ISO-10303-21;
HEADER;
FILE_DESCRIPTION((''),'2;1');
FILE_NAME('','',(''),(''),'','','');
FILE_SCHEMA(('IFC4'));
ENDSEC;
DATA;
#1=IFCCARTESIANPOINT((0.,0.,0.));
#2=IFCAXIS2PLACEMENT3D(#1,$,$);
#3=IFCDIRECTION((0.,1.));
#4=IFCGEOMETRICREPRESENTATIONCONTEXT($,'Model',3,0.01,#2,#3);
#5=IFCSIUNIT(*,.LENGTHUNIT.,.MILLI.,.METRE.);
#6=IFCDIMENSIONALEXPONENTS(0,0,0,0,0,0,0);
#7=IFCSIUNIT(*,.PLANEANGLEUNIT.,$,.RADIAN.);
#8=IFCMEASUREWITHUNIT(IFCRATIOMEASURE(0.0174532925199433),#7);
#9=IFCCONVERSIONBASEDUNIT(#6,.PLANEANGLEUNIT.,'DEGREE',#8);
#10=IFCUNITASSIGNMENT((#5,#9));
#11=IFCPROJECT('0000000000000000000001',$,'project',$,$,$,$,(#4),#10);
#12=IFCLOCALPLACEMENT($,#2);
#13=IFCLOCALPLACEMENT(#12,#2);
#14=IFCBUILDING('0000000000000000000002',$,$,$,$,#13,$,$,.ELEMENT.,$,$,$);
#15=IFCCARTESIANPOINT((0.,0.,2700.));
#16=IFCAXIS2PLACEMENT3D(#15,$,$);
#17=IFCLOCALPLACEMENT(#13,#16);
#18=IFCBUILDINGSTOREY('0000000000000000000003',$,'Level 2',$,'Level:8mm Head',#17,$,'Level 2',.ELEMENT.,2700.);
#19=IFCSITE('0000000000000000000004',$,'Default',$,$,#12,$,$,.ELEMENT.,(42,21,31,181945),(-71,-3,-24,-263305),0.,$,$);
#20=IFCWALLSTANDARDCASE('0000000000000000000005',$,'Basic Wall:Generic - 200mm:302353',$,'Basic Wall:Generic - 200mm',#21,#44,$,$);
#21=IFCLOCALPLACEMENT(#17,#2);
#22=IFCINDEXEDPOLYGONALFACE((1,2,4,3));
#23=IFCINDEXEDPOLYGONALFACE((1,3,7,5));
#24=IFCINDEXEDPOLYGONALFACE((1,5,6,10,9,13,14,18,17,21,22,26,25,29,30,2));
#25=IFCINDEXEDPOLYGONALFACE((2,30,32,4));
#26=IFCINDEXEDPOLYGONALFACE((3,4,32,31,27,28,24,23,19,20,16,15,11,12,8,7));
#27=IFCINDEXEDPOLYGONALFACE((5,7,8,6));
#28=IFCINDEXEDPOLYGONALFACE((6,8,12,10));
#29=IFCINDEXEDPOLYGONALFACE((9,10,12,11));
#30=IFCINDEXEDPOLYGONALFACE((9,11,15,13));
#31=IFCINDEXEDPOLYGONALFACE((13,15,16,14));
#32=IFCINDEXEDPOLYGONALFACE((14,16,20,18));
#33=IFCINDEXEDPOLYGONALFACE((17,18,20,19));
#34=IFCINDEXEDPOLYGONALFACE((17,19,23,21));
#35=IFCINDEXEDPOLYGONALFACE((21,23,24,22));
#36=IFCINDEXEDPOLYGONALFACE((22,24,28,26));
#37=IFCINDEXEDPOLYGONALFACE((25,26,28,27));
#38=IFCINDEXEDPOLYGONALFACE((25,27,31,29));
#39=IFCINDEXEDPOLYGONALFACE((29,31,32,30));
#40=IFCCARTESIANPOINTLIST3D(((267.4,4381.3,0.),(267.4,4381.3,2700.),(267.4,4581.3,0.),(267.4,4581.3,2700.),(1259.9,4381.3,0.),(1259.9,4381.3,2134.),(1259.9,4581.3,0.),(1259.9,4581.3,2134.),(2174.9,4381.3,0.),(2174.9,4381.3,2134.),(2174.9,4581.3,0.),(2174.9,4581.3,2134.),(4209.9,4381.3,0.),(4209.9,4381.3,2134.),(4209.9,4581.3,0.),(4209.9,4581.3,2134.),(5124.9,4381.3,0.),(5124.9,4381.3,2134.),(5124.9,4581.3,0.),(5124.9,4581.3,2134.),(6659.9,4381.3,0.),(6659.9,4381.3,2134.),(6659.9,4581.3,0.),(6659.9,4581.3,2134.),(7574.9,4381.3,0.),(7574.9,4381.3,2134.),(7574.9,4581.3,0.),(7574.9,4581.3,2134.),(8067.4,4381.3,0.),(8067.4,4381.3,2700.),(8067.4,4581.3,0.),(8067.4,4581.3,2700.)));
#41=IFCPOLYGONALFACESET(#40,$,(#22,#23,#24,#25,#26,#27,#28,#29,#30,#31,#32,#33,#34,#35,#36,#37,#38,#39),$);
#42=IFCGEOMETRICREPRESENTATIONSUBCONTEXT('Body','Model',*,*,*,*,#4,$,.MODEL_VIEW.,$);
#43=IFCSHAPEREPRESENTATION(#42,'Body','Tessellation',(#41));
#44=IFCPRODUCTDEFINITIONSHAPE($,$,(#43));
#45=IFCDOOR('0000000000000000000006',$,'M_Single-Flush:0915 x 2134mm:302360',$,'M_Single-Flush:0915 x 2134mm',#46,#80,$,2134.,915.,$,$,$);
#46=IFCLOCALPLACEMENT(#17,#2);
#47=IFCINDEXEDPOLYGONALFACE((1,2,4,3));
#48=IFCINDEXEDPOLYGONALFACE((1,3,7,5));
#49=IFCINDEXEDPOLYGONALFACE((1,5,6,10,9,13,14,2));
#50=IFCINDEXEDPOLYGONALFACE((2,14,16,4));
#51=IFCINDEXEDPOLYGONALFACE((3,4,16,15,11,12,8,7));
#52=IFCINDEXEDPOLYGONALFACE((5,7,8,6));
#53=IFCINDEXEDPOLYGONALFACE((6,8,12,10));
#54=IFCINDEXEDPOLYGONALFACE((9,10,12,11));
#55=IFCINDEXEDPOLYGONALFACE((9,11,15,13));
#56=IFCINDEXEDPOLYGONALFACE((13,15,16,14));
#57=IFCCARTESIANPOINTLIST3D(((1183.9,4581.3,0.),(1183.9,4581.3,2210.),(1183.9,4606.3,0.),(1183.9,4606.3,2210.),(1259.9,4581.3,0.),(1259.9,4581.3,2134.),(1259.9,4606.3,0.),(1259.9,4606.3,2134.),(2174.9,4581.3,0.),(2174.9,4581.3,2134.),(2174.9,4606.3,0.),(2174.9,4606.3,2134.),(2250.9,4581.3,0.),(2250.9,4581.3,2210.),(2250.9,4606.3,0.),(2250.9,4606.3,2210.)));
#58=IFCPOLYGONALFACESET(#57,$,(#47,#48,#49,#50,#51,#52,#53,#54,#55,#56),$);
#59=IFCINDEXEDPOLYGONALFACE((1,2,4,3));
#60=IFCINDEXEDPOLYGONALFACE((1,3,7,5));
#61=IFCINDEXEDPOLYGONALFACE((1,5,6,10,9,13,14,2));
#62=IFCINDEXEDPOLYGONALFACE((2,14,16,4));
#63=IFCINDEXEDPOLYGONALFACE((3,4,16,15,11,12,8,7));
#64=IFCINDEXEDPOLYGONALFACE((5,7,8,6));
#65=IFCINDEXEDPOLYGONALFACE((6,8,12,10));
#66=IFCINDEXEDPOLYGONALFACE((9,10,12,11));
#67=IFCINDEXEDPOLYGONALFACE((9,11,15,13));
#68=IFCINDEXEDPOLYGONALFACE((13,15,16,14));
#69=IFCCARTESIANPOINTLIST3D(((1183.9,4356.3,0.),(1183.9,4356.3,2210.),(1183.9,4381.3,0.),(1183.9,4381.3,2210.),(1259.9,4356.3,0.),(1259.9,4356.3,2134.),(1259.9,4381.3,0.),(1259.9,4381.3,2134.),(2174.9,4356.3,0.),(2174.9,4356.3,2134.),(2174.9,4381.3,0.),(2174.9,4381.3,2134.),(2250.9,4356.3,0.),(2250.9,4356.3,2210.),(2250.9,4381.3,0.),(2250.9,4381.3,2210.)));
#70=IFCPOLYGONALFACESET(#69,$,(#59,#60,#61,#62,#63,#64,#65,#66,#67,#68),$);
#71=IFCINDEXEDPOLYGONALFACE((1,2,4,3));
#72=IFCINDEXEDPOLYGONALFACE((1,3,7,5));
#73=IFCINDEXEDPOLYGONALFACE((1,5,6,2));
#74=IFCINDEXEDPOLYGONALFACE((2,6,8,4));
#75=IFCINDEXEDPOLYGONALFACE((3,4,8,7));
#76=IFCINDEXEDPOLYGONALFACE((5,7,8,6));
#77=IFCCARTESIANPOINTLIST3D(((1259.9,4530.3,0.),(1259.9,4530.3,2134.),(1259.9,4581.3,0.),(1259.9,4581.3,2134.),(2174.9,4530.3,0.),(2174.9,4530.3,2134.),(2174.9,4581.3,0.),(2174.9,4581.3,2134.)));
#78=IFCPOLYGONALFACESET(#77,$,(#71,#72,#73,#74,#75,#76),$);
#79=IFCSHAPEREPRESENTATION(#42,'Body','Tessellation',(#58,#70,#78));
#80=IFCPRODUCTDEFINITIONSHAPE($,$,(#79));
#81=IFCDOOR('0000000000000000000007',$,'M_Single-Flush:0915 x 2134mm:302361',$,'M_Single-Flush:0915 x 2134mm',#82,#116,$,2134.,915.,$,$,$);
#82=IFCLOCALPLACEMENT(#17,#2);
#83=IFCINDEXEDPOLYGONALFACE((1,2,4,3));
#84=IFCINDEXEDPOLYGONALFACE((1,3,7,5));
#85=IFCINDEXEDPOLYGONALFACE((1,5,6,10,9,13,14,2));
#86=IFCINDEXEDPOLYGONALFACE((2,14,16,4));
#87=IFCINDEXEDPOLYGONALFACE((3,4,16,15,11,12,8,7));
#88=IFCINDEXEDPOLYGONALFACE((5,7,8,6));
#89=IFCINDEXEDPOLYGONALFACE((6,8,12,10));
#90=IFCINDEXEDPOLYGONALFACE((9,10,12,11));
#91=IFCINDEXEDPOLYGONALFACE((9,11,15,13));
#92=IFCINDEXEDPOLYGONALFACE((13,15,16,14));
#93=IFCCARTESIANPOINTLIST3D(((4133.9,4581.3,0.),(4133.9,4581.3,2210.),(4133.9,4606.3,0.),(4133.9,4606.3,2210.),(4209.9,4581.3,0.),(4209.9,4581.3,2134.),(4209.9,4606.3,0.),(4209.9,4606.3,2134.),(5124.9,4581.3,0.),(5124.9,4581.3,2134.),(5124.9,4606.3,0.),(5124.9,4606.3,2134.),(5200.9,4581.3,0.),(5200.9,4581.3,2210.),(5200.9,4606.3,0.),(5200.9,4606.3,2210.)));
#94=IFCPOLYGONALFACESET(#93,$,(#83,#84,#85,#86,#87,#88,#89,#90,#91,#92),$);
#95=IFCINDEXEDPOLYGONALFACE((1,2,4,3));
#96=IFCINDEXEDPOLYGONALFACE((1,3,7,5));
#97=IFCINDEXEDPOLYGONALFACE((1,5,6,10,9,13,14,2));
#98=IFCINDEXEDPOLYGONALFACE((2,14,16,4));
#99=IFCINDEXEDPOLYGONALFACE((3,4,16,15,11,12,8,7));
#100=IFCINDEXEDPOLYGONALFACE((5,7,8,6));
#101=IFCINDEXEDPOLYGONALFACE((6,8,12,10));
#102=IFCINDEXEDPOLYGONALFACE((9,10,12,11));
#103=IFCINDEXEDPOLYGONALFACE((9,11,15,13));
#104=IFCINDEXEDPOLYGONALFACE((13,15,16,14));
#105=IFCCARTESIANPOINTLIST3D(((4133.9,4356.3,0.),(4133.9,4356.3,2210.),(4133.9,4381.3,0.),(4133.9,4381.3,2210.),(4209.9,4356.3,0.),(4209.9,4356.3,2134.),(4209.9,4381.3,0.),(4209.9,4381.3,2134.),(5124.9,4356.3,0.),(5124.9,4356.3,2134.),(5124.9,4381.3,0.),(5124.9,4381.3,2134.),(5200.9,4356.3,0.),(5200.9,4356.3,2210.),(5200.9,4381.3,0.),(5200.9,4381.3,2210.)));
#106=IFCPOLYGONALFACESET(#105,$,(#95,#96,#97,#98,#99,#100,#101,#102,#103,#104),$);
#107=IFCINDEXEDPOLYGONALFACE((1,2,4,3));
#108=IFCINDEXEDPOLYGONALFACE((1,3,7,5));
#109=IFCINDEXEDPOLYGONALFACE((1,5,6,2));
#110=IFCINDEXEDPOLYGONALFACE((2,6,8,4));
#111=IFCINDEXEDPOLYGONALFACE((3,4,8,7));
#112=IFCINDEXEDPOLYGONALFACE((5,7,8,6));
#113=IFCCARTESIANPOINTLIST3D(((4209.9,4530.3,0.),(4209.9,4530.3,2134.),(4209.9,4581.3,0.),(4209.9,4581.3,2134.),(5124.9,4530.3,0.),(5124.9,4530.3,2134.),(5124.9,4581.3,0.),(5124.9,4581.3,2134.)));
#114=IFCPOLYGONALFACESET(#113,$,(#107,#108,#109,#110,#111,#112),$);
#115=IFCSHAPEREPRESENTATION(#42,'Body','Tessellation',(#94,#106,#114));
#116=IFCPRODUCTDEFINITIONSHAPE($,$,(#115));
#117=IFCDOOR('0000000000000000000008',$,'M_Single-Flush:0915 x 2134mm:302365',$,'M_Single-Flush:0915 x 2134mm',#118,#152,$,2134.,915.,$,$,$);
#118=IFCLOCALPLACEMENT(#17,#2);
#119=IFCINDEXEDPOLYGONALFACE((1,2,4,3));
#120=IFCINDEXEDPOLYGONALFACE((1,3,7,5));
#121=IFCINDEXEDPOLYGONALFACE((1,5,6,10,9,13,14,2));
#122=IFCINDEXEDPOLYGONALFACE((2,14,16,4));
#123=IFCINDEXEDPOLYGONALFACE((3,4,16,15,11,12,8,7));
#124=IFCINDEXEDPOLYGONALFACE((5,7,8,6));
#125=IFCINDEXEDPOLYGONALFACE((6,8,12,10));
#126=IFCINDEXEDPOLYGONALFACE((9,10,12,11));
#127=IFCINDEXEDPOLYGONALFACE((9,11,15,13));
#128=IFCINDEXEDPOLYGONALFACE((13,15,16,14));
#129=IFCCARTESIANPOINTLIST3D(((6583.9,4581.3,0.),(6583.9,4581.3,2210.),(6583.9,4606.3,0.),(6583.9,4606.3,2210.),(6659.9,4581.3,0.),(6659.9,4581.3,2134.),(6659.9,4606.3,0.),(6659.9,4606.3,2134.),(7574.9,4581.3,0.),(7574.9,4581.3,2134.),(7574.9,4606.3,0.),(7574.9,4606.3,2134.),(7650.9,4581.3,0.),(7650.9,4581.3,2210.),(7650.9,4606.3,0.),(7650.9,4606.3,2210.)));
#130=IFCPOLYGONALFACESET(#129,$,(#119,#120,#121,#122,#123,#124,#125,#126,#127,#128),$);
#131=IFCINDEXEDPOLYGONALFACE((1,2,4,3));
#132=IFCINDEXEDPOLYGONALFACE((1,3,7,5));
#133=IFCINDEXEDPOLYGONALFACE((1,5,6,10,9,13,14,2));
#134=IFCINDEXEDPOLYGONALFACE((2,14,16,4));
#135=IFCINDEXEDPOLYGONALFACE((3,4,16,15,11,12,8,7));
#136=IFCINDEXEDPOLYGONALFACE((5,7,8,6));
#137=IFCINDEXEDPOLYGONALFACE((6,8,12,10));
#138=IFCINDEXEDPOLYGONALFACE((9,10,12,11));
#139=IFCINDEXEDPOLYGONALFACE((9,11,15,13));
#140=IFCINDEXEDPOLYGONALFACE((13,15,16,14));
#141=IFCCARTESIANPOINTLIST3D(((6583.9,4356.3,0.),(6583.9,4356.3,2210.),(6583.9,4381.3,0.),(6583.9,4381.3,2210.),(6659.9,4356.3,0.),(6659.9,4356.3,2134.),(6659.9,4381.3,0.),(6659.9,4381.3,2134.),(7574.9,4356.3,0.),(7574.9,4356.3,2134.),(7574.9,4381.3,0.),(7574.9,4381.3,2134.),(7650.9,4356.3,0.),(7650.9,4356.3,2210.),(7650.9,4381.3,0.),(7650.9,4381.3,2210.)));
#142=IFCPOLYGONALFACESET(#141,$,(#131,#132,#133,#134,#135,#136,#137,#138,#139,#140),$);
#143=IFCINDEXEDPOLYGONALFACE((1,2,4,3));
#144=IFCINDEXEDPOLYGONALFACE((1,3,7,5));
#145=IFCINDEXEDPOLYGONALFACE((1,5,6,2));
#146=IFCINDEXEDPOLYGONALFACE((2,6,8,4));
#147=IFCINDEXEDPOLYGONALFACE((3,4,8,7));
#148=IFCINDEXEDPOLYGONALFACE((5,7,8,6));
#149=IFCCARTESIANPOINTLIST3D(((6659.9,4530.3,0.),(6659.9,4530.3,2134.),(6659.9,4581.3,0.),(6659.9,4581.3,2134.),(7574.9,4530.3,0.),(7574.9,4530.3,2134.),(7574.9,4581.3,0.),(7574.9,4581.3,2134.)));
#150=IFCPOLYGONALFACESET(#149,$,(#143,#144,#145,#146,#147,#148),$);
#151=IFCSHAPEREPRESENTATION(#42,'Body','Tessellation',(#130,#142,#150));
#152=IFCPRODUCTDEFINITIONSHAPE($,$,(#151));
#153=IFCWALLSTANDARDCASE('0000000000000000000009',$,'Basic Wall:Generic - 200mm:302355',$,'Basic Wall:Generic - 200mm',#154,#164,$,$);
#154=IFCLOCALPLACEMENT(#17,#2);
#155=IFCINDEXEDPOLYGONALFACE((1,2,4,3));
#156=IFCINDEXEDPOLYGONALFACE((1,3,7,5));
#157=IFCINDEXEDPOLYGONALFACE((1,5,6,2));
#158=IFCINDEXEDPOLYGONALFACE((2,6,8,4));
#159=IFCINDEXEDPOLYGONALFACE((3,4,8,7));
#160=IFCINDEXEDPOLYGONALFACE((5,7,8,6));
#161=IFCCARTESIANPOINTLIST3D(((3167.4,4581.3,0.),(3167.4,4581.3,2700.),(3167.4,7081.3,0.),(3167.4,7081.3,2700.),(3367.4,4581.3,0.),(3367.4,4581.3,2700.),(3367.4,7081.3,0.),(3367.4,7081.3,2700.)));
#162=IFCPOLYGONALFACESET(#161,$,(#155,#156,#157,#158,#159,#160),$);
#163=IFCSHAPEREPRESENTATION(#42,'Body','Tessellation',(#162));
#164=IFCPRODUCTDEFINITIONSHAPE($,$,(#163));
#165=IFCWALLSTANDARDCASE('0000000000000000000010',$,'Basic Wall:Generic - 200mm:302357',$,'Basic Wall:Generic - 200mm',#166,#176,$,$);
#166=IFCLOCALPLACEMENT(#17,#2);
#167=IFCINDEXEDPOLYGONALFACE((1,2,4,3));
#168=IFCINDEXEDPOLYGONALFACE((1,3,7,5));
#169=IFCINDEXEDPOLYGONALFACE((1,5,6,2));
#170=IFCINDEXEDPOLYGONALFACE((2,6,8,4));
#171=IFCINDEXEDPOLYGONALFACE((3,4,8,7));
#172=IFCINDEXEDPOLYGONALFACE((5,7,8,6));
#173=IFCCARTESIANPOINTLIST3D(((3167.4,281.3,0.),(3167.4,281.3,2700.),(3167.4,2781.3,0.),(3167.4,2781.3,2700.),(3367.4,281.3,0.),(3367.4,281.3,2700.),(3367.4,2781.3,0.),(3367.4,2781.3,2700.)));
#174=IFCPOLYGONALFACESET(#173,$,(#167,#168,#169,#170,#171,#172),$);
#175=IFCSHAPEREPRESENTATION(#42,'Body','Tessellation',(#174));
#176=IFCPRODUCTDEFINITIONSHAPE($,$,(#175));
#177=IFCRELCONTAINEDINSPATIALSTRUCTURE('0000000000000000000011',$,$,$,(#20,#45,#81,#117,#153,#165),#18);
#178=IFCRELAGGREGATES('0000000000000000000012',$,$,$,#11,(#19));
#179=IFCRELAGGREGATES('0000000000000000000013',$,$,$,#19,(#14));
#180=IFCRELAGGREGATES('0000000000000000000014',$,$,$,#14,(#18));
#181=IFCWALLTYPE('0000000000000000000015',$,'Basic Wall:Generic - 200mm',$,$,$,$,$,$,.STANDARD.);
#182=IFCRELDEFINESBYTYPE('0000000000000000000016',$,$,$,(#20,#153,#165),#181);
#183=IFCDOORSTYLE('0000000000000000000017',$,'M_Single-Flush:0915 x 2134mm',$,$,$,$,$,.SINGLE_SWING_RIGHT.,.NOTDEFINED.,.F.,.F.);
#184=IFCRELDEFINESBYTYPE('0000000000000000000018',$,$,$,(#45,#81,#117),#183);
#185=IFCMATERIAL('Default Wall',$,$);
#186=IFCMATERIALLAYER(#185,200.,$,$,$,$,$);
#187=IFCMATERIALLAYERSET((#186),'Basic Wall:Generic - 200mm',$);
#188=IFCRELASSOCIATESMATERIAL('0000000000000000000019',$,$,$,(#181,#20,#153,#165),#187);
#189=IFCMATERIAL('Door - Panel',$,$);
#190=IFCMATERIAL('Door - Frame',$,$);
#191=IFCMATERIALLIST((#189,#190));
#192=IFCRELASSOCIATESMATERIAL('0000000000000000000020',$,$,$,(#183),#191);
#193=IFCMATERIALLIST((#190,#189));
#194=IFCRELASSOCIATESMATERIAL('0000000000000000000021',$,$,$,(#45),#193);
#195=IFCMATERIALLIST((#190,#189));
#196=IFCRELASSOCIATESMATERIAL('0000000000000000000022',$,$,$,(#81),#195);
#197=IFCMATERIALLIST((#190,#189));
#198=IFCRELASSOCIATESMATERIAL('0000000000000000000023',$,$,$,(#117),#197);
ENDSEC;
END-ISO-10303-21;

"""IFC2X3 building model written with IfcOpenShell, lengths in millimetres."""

from ifc_helpers import new_model, entity, si_unit, converted_unit, direction, frame, frame_2d, origin, place, context, subcontext, project, spatial, polyline, rectangle, outline, extrude, source, transform, mapped, material, material_list, layer, layer_set, layer_usage, type_object, type_shapes, element, fill, save


model = new_model("IFC2X3")

# Units and contexts
model_context = context("Model", 3, precision=0.01, world=origin(), true_north=direction((0.0, 1.0)))
body_context = subcontext(model_context, "Body", "Model", "MODEL_VIEW")
ifc_project = project(units=[si_unit("LENGTHUNIT", "METRE", prefix="MILLI"), converted_unit("PLANEANGLEUNIT", "DEGREE", entity("IfcRatioMeasure", 0.0174532925199433), si_unit("PLANEANGLEUNIT", "RADIAN"), dimensions=[0, 0, 0, 0, 0, 0, 0])], contexts=[model_context])

# Site, building, storey
site_placement = place(None, origin())
site = spatial("IfcSite", under=ifc_project, at=site_placement, Name="Default", CompositionType="ELEMENT", RefLatitude=(42, 21, 31, 181945), RefLongitude=(-71, -3, -24, -263305), RefElevation=0.0)
building_placement = place(site_placement, origin())
building = spatial("IfcBuilding", under=site, at=building_placement, CompositionType="ELEMENT")
storey_placement = place(building_placement, frame((0.0, 0.0, 2700.0)))
storey = spatial("IfcBuildingStorey", under=building, at=storey_placement, Name="Level 2", ObjectType="Level:8mm Head", LongName="Level 2", CompositionType="ELEMENT", Elevation=2700.0)

# Shared definitions
ifc_material_1 = material(Name="Default Wall")
ifc_layer_1 = layer(ifc_material_1, 200.0)
ifc_layer_set_1 = layer_set([ifc_layer_1], Name="Basic Wall:Generic - 200mm")
wall_type = type_object("IfcWallType", Name="Basic Wall:Generic - 200mm", PredefinedType="STANDARD", material=ifc_layer_set_1)

# Wall, openings, doors
ifc_layer_usage_1 = layer_usage(ifc_layer_set_1, "AXIS2", "NEGATIVE", 100.0)
wall_1_placement = place(storey_placement, frame((267.4, 4481.3, 0.0)))
wall_1 = element("IfcWallStandardCase", 1, at=wall_1_placement, inside=storey, type_object=wall_type, material=ifc_layer_usage_1, Name="Basic Wall:Generic - 200mm:302353", ObjectType="Basic Wall:Generic - 200mm", context=body_context, shape_type="SweptSolid", body=[
    extrude(rectangle(XDim=7800.0, YDim=200.0, at=frame_2d((3900.0, 0.0), x_axis=(-1.0, 0.0))), origin(), (0.0, 0.0, 1.0), 2700.0),
])
opening_1_placement = place(wall_1_placement, frame((992.5, -100.0, 0.0)))
opening_1 = element("IfcOpeningElement", 2, at=opening_1_placement, cuts=wall_1, ObjectType="Opening", context=body_context, shape_type="SweptSolid", body=[
    extrude(rectangle(XDim=915.0, YDim=2134.0, at=frame_2d((1067.0, 457.5), x_axis=(0.0, 1.0))), frame((0.0, 0.0, 0.0), z_axis=(0.0, 1.0, 0.0), x_axis=(0.0, 0.0, 1.0)), (0.0, 0.0, 1.0), 200.0),
])
opening_2_placement = place(wall_1_placement, frame((3942.5, -100.0, 0.0)))
opening_2 = element("IfcOpeningElement", 3, at=opening_2_placement, cuts=wall_1, ObjectType="Opening", context=body_context, shape_type="SweptSolid", body=[
    extrude(rectangle(XDim=915.0, YDim=2134.0, at=frame_2d((1067.0, 457.5), x_axis=(0.0, 1.0))), frame((0.0, 0.0, 0.0), z_axis=(0.0, 1.0, 0.0), x_axis=(0.0, 0.0, 1.0)), (0.0, 0.0, 1.0), 200.0),
])
opening_3_placement = place(wall_1_placement, frame((6392.5, -100.0, 0.0)))
opening_3 = element("IfcOpeningElement", 4, at=opening_3_placement, cuts=wall_1, ObjectType="Opening", context=body_context, shape_type="SweptSolid", body=[
    extrude(rectangle(XDim=915.0, YDim=2134.0, at=frame_2d((1067.0, 457.5), x_axis=(0.0, 1.0))), frame((0.0, 0.0, 0.0), z_axis=(0.0, 1.0, 0.0), x_axis=(0.0, 0.0, 1.0)), (0.0, 0.0, 1.0), 200.0),
])
ifc_material_2 = material(Name="Door - Frame")
ifc_material_3 = material(Name="Door - Panel")
ifc_material_list_1 = material_list([ifc_material_2, ifc_material_3])
ifc_material_list_2 = material_list([ifc_material_3, ifc_material_2])
door_style = type_object("IfcDoorStyle", Name="M_Single-Flush:0915 x 2134mm", ConstructionType="NOTDEFINED", OperationType="SINGLE_SWING_RIGHT", ParameterTakesPrecedence=False, Sizeable=False, material=ifc_material_list_2)
shared_shape_1 = source(origin(), body_context, "Body", "SweptSolid", [
    extrude(outline(polyline([(-533.5, -1124.0), (533.5, -1124.0), (533.5, 1086.0), (457.5, 1086.0), (457.5, -1048.0), (-457.5, -1048.0), (-457.5, 1086.0), (-533.5, 1086.0), (-533.5, -1124.0)])), frame((457.5, 200.0, 1086.0), z_axis=(0.0, 1.0, 0.0), x_axis=(1.0, 0.0, 0.0)), (0.0, 0.0, 1.0), 25.0),
    extrude(outline(polyline([(-1124.0, -533.5), (1086.0, -533.5), (1086.0, -457.5), (-1048.0, -457.5), (-1048.0, 457.5), (1086.0, 457.5), (1086.0, 533.5), (-1124.0, 533.5), (-1124.0, -533.5)])), frame((457.5, -25.0, 1086.0), z_axis=(0.0, 1.0, 0.0), x_axis=(0.0, 0.0, -1.0)), (0.0, 0.0, 1.0), 25.0),
    extrude(rectangle(XDim=51.0, YDim=915.0, at=frame_2d((0.0, 0.0), x_axis=(1.0, 0.0))), frame((457.5, 174.5, 0.0), z_axis=(0.0, 0.0, 1.0), x_axis=(0.0, 1.0, 0.0)), (0.0, 0.0, 1.0), 2134.0),
])
type_shapes(door_style, [shared_shape_1])
door_1_placement = place(opening_1_placement, origin())
door_1 = element("IfcDoor", 5, at=door_1_placement, inside=storey, type_object=door_style, material=ifc_material_list_1, Name="M_Single-Flush:0915 x 2134mm:302360", ObjectType="M_Single-Flush:0915 x 2134mm", OverallHeight=2134.0, OverallWidth=915.0, context=body_context, shape_type="MappedRepresentation", body=[
    mapped(shared_shape_1, transform((0.0, 0.0, 0.0), scale=1.0)),
])
fill(opening_1, door_1)
ifc_material_list_3 = material_list([ifc_material_2, ifc_material_3])
door_2_placement = place(opening_2_placement, origin())
door_2 = element("IfcDoor", 6, at=door_2_placement, inside=storey, type_object=door_style, material=ifc_material_list_3, Name="M_Single-Flush:0915 x 2134mm:302361", ObjectType="M_Single-Flush:0915 x 2134mm", OverallHeight=2134.0, OverallWidth=915.0, context=body_context, shape_type="MappedRepresentation", body=[
    mapped(shared_shape_1, transform((0.0, 0.0, 0.0), scale=1.0)),
])
fill(opening_2, door_2)
ifc_material_list_4 = material_list([ifc_material_2, ifc_material_3])
door_3_placement = place(opening_3_placement, origin())
door_3 = element("IfcDoor", 7, at=door_3_placement, inside=storey, type_object=door_style, material=ifc_material_list_4, Name="M_Single-Flush:0915 x 2134mm:302365", ObjectType="M_Single-Flush:0915 x 2134mm", OverallHeight=2134.0, OverallWidth=915.0, context=body_context, shape_type="MappedRepresentation", body=[
    mapped(shared_shape_1, transform((0.0, 0.0, 0.0), scale=1.0)),
])
fill(opening_3, door_3)

# Walls
ifc_layer_usage_2 = layer_usage(ifc_layer_set_1, "AXIS2", "NEGATIVE", 100.0)
wall_2_placement = place(storey_placement, frame((3267.4, 7081.3, 0.0), z_axis=(0.0, 0.0, 1.0), x_axis=(0.0, -1.0, 0.0)))
element("IfcWallStandardCase", 8, at=wall_2_placement, inside=storey, type_object=wall_type, material=ifc_layer_usage_2, Name="Basic Wall:Generic - 200mm:302355", ObjectType="Basic Wall:Generic - 200mm", context=body_context, shape_type="SweptSolid", body=[
    extrude(rectangle(XDim=2500.0, YDim=200.0, at=frame_2d((1250.0, 0.0), x_axis=(-1.0, 0.0))), origin(), (0.0, 0.0, 1.0), 2700.0),
])
ifc_layer_usage_3 = layer_usage(ifc_layer_set_1, "AXIS2", "NEGATIVE", 100.0)
wall_3_placement = place(storey_placement, frame((3267.4, 2781.3, 0.0), z_axis=(0.0, 0.0, 1.0), x_axis=(0.0, -1.0, 0.0)))
element("IfcWallStandardCase", 9, at=wall_3_placement, inside=storey, type_object=wall_type, material=ifc_layer_usage_3, Name="Basic Wall:Generic - 200mm:302357", ObjectType="Basic Wall:Generic - 200mm", context=body_context, shape_type="SweptSolid", body=[
    extrude(rectangle(XDim=2500.0, YDim=200.0, at=frame_2d((1250.0, 0.0), x_axis=(-1.0, 0.0))), origin(), (0.0, 0.0, 1.0), 2700.0),
])

save(model, "model.ifc")
